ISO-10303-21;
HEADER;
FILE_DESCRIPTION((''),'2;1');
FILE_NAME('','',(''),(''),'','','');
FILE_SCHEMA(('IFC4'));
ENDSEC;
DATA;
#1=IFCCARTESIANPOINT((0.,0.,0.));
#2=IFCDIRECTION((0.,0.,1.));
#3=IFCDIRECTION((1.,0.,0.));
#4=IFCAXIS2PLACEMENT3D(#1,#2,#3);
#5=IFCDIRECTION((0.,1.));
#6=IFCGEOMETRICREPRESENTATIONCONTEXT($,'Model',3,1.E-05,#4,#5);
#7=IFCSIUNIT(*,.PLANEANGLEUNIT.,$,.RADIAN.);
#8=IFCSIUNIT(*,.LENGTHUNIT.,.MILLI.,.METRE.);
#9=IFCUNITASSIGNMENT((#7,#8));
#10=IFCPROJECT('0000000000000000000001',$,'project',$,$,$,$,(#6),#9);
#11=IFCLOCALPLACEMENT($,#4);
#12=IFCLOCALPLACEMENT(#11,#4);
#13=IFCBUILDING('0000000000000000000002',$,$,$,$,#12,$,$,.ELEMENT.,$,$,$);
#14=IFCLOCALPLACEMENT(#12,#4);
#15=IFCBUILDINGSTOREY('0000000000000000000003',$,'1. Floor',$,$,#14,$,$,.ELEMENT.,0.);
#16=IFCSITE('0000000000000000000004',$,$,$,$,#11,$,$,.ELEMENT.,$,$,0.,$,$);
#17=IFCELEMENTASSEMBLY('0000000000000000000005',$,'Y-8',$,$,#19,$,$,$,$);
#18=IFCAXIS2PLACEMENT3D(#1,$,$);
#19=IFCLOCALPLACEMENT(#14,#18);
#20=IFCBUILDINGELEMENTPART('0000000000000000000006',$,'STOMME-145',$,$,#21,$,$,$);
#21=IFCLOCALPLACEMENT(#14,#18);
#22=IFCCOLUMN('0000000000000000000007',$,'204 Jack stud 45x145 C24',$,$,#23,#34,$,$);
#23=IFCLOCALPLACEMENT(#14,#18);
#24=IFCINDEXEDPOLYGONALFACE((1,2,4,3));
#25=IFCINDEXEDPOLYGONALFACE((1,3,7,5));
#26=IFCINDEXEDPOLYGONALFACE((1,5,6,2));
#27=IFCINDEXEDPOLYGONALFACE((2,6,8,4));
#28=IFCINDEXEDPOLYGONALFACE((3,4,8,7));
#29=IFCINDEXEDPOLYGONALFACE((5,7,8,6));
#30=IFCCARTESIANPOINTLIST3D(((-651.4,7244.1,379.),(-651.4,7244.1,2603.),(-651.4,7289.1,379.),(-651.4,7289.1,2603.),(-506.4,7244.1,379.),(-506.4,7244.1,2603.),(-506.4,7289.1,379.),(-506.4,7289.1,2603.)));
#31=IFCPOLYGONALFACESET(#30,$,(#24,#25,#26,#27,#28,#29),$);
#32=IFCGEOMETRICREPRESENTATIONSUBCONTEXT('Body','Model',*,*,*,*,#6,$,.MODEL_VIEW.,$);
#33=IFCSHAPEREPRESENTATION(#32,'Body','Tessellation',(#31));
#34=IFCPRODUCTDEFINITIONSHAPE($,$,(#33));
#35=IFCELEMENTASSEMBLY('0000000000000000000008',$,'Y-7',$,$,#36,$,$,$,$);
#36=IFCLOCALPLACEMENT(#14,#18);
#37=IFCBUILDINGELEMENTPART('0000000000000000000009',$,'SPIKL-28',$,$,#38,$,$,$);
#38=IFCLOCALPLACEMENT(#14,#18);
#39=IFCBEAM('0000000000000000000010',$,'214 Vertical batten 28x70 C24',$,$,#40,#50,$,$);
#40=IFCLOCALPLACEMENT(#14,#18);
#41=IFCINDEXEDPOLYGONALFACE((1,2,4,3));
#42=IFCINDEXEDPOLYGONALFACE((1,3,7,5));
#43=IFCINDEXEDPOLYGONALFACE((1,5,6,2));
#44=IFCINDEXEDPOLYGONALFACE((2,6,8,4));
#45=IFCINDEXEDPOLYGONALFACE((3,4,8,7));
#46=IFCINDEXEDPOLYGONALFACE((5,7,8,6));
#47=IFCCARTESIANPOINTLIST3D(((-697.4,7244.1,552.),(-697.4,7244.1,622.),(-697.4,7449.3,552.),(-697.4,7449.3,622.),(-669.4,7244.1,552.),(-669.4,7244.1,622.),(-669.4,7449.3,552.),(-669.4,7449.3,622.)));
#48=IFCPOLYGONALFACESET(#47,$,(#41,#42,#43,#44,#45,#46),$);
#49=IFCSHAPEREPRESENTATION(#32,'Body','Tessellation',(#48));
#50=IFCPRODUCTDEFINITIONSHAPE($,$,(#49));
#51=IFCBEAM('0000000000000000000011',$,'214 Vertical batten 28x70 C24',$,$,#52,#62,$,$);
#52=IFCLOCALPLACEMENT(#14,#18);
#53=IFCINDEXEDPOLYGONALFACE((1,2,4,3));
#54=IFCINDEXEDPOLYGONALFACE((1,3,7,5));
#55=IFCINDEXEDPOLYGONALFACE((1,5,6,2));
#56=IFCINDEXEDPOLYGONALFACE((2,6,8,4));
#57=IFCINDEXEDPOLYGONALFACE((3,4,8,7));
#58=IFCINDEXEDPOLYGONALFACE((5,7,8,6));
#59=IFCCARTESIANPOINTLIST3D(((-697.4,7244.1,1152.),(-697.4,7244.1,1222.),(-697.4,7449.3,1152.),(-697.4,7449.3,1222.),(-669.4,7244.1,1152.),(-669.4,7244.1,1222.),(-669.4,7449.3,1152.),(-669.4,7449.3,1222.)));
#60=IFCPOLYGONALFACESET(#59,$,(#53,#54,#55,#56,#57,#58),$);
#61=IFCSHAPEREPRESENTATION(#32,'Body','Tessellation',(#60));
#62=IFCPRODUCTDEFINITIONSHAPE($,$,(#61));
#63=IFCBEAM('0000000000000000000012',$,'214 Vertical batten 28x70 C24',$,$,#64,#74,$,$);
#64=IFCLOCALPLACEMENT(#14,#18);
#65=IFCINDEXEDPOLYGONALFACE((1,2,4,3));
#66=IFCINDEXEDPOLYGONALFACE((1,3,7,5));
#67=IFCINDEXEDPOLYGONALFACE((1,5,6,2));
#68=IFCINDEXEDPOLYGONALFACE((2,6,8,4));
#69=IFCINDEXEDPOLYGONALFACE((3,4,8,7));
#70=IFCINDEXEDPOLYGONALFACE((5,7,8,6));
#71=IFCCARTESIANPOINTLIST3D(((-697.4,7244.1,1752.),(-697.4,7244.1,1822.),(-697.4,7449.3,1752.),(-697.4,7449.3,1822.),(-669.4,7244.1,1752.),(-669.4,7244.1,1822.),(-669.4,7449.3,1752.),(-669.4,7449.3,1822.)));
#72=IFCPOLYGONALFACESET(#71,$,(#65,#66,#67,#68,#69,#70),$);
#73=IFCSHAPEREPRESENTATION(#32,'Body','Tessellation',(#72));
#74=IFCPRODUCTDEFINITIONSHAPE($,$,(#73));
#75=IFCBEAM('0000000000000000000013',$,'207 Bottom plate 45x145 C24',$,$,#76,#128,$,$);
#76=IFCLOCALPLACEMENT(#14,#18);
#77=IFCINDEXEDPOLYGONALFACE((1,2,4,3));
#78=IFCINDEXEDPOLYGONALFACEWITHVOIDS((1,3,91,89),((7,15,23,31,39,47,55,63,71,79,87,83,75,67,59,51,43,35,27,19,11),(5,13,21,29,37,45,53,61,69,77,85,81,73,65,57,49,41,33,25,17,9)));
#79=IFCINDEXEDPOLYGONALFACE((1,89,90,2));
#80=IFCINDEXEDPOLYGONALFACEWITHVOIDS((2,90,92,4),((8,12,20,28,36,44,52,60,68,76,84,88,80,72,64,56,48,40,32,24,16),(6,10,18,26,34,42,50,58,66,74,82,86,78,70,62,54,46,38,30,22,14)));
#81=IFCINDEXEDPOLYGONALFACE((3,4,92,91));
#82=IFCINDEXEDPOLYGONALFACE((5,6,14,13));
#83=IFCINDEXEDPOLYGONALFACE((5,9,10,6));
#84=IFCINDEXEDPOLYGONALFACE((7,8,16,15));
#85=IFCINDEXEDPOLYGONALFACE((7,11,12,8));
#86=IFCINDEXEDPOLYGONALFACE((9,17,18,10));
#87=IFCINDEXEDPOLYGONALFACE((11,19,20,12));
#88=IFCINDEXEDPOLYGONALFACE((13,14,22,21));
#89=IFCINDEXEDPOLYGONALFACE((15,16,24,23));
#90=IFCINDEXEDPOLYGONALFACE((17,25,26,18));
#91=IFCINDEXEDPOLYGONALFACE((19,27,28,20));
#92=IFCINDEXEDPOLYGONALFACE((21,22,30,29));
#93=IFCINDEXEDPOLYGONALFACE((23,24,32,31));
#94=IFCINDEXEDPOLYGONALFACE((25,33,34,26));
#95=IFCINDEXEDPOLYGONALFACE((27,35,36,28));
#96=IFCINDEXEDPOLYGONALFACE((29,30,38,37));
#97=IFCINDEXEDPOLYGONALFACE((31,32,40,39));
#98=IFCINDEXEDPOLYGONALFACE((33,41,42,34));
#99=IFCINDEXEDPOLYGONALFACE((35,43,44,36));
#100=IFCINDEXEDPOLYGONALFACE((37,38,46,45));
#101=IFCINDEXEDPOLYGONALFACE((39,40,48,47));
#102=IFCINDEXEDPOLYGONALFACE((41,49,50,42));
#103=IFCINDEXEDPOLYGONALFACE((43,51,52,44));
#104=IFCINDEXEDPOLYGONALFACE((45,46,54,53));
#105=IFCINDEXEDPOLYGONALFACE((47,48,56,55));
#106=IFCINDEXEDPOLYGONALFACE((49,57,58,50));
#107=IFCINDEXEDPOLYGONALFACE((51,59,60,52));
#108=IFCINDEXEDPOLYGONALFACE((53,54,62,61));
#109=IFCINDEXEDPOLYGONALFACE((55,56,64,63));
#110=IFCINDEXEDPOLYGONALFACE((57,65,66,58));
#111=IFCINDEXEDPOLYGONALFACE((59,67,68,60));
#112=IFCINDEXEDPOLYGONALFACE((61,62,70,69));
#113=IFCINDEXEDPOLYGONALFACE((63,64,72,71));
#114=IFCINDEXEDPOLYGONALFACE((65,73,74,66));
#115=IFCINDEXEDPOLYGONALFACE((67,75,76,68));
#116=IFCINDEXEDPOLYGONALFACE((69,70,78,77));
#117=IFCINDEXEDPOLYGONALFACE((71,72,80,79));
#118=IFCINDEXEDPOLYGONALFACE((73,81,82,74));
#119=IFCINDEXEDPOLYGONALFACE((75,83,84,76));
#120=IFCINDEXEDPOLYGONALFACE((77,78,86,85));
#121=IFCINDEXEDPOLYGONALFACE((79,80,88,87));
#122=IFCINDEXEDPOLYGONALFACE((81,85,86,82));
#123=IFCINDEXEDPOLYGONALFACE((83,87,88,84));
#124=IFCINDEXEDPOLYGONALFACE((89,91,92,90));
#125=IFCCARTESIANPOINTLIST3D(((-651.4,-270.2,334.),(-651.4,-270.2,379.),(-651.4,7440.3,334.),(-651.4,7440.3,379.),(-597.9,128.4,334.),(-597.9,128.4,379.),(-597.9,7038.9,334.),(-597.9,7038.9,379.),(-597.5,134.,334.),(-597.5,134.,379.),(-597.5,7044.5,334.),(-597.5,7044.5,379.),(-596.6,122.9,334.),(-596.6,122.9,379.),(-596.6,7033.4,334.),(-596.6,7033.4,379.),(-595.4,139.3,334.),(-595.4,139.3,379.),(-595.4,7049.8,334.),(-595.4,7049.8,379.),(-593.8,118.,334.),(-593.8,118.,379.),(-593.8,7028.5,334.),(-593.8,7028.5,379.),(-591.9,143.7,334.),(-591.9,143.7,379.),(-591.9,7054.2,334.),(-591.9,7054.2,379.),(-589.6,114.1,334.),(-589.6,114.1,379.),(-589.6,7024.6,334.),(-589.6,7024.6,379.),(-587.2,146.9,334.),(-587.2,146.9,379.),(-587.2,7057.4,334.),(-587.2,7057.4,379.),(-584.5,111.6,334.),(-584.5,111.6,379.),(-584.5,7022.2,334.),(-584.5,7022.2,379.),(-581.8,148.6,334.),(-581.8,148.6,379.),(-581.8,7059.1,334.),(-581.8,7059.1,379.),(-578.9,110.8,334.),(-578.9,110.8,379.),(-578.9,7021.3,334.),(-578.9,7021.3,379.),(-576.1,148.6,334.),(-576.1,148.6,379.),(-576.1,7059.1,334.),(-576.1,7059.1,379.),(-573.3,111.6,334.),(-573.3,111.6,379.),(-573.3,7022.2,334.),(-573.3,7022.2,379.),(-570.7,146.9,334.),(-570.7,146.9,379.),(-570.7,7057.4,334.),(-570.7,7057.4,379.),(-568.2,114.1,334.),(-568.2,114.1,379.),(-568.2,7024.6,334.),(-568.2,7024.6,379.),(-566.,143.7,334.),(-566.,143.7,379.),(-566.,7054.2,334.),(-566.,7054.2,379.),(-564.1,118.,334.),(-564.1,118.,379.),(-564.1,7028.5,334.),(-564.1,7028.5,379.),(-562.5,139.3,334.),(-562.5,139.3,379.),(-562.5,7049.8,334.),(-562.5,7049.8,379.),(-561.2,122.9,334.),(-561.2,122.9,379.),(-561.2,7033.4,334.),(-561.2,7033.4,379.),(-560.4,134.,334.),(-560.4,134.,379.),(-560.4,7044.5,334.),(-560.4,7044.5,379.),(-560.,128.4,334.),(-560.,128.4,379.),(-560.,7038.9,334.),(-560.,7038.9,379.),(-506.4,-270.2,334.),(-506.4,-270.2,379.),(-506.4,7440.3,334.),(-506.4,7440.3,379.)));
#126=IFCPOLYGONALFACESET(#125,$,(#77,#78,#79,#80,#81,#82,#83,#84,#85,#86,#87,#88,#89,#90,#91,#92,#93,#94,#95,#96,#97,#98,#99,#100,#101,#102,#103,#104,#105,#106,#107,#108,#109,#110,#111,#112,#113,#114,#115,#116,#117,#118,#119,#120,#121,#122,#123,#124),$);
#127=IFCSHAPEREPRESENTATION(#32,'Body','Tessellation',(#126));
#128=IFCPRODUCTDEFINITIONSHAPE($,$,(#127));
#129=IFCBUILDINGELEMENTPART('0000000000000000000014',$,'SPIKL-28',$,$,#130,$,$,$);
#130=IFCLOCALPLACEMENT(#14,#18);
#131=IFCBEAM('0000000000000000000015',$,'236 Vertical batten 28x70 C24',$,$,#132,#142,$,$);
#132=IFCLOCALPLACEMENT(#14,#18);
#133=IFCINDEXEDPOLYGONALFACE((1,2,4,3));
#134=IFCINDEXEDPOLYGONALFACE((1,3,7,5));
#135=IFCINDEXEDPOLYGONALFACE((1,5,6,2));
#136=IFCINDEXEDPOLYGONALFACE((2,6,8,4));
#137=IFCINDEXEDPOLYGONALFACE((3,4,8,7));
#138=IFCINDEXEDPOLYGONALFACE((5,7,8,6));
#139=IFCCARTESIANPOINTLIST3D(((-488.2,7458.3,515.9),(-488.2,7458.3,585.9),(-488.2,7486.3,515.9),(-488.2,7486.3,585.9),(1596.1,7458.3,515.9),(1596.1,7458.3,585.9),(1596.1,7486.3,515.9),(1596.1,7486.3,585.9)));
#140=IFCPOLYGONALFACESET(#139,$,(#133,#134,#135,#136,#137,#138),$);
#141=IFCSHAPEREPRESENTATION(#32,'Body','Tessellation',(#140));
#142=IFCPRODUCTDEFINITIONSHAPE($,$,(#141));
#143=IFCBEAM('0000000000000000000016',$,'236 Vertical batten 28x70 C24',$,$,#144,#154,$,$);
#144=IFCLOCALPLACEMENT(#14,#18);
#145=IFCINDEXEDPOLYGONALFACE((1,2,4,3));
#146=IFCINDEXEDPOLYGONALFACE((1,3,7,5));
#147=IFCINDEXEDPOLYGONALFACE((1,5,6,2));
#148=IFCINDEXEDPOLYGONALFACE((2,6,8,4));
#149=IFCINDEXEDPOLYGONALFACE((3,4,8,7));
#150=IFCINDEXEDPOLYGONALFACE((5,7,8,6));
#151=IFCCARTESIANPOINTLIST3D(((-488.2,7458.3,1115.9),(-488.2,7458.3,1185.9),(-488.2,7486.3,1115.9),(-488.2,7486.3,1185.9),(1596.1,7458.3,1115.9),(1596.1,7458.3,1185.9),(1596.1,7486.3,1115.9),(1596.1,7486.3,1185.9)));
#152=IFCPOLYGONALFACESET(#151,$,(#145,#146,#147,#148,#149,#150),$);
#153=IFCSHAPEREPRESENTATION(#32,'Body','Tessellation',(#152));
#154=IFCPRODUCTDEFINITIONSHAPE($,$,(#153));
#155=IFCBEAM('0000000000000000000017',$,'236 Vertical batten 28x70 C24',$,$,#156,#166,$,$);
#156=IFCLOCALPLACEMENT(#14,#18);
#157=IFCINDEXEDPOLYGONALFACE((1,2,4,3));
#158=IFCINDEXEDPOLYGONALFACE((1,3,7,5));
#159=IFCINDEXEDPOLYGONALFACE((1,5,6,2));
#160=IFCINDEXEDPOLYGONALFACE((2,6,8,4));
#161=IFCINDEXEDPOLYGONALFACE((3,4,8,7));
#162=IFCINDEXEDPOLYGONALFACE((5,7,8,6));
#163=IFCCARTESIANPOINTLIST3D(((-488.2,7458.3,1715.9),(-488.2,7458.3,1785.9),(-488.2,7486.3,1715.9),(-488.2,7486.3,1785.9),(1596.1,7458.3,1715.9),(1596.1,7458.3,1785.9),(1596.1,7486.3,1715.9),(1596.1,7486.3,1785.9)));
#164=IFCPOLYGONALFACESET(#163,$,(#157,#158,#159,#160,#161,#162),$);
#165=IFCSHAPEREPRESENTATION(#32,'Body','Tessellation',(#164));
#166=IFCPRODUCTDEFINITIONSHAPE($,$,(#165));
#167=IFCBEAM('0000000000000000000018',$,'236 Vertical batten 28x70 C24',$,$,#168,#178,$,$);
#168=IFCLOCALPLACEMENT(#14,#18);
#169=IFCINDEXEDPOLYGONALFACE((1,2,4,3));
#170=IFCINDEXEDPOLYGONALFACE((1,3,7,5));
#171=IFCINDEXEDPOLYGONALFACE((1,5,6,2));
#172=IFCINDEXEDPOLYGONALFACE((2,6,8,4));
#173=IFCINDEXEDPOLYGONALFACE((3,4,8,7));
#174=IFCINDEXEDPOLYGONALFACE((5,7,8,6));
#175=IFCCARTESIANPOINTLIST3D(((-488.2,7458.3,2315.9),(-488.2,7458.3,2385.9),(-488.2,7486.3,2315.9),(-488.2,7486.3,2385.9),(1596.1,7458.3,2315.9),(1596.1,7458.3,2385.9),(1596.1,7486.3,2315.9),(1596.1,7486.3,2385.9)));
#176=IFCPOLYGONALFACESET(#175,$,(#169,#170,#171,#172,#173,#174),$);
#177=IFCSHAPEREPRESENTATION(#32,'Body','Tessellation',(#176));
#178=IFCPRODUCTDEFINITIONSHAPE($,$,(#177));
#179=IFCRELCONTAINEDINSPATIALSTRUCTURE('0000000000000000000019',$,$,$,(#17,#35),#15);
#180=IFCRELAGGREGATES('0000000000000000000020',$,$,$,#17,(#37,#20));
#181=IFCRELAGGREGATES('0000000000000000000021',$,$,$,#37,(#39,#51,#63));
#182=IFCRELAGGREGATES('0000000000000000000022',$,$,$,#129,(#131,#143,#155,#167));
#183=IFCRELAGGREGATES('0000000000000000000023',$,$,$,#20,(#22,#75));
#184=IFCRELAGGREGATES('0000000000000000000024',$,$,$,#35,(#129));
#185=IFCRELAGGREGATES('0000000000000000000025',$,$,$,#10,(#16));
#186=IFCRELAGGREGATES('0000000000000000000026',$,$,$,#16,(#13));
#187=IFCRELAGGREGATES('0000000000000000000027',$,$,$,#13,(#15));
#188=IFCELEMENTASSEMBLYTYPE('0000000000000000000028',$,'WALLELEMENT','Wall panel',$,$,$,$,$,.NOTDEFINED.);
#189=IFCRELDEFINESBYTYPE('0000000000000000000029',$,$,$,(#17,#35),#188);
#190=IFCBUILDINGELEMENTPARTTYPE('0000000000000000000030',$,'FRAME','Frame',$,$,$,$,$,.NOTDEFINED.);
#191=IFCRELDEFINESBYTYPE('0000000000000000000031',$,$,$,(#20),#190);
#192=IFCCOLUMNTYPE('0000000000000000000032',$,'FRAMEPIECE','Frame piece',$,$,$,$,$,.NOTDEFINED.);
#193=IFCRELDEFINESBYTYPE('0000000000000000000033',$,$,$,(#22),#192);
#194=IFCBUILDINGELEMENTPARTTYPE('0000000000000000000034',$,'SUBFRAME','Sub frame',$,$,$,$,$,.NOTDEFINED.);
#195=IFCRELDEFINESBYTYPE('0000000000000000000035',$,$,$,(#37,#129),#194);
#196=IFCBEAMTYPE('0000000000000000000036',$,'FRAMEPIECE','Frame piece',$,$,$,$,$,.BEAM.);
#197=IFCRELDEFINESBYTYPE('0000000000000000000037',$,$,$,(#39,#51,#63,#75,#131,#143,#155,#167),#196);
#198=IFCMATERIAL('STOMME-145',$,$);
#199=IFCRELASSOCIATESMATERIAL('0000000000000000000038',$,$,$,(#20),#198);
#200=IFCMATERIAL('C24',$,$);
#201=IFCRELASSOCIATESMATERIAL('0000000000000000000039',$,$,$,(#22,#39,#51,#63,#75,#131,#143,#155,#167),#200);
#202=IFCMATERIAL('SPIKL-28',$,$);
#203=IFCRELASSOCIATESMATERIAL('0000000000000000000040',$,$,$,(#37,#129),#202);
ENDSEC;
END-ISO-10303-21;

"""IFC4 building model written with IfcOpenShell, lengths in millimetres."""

from ifc_helpers import new_model, si_unit, direction, frame, origin_with_axes, origin_2d_with_axis, place, context, subcontext, project, spatial, rectangle, circle, extrude, boolean, material, type_object, element, aggregate, save


model = new_model("IFC4")

# Units and contexts
model_context = context("Model", 3, precision=1e-05, world=origin_with_axes(), true_north=direction((0.0, 1.0)))
body_context = subcontext(model_context, "Body", "Model", "MODEL_VIEW")
ifc_project = project(units=[si_unit("PLANEANGLEUNIT", "RADIAN"), si_unit("LENGTHUNIT", "METRE", prefix="MILLI")], contexts=[model_context])

# Site, building, storey
site_placement = place(None, origin_with_axes())
site = spatial("IfcSite", under=ifc_project, at=site_placement, CompositionType="ELEMENT", RefElevation=0.0)
building_placement = place(site_placement, origin_with_axes())
building = spatial("IfcBuilding", under=site, at=building_placement, CompositionType="ELEMENT")
storey_placement = place(building_placement, origin_with_axes())
storey = spatial("IfcBuildingStorey", under=building, at=storey_placement, Name="1. Floor", CompositionType="ELEMENT", Elevation=0.0)

# Element assemblies, building element part, column
element_assembly_type = type_object("IfcElementAssemblyType", Name="WALLELEMENT", Description="Wall panel", PredefinedType="NOTDEFINED")
assembly_1_placement = place(storey_placement, origin_with_axes())
assembly_1 = element("IfcElementAssembly", 1, at=assembly_1_placement, inside=storey, type_object=element_assembly_type, Name="Y-8")
ifc_material_1 = material(Name="STOMME-145")
building_element_part_type_1 = type_object("IfcBuildingElementPartType", Name="FRAME", Description="Frame", PredefinedType="NOTDEFINED")
building_element_part_1_placement = place(storey_placement, origin_with_axes())
building_element_part_1 = element("IfcBuildingElementPart", 2, at=building_element_part_1_placement, type_object=building_element_part_type_1, material=ifc_material_1, Name="STOMME-145")
ifc_material_2 = material(Name="C24")
column_type = type_object("IfcColumnType", Name="FRAMEPIECE", Description="Frame piece", PredefinedType="NOTDEFINED")
column_1_placement = place(storey_placement, frame((-578.9, 7266.6, 379.0), z_axis=(0.0, 0.0, 1.0), x_axis=(0.0, 1.0, 0.0)))
column_1 = element("IfcColumn", 3, at=column_1_placement, type_object=column_type, material=ifc_material_2, Name="204 Jack stud 45x145 C24", context=body_context, shape_type="SweptSolid", body=[
    extrude(rectangle(XDim=45.0, YDim=145.0, at=origin_2d_with_axis()), origin_with_axes(), (0.0, 0.0, 1.0), 2224.0),
])
assembly_2_placement = place(storey_placement, origin_with_axes())
assembly_2 = element("IfcElementAssembly", 4, at=assembly_2_placement, inside=storey, type_object=element_assembly_type, Name="Y-7")

# Building element part
ifc_material_3 = material(Name="SPIKL-28")
building_element_part_type_2 = type_object("IfcBuildingElementPartType", Name="SUBFRAME", Description="Sub frame", PredefinedType="NOTDEFINED")
building_element_part_2_placement = place(storey_placement, origin_with_axes())
building_element_part_2 = element("IfcBuildingElementPart", 5, at=building_element_part_2_placement, type_object=building_element_part_type_2, material=ifc_material_3, Name="SPIKL-28")
aggregate(assembly_1, [building_element_part_2, building_element_part_1])

# Beams
beam_type = type_object("IfcBeamType", Name="FRAMEPIECE", Description="Frame piece", PredefinedType="BEAM")
beam_1_placement = place(storey_placement, frame((-683.4, 7244.1, 587.0), z_axis=(0.0, 1.0, 0.0), x_axis=(-1.0, 0.0, 0.0)))
beam_1 = element("IfcBeam", 6, at=beam_1_placement, type_object=beam_type, material=ifc_material_2, Name="214 Vertical batten 28x70 C24", context=body_context, shape_type="SweptSolid", body=[
    extrude(rectangle(XDim=28.0, YDim=70.0, at=origin_2d_with_axis()), origin_with_axes(), (0.0, 0.0, 1.0), 205.2),
])
beam_2_placement = place(storey_placement, frame((-683.4, 7244.1, 1187.0), z_axis=(0.0, 1.0, 0.0), x_axis=(-1.0, 0.0, 0.0)))
beam_2 = element("IfcBeam", 7, at=beam_2_placement, type_object=beam_type, material=ifc_material_2, Name="214 Vertical batten 28x70 C24", context=body_context, shape_type="SweptSolid", body=[
    extrude(rectangle(XDim=28.0, YDim=70.0, at=origin_2d_with_axis()), origin_with_axes(), (0.0, 0.0, 1.0), 205.2),
])
beam_3_placement = place(storey_placement, frame((-683.4, 7244.1, 1787.0), z_axis=(0.0, 1.0, 0.0), x_axis=(-1.0, 0.0, 0.0)))
beam_3 = element("IfcBeam", 8, at=beam_3_placement, type_object=beam_type, material=ifc_material_2, Name="214 Vertical batten 28x70 C24", context=body_context, shape_type="SweptSolid", body=[
    extrude(rectangle(XDim=28.0, YDim=70.0, at=origin_2d_with_axis()), origin_with_axes(), (0.0, 0.0, 1.0), 205.2),
])
aggregate(building_element_part_2, [beam_1, beam_2, beam_3])
beam_4_placement = place(storey_placement, frame((-578.9, 7440.3, 356.5), z_axis=(0.0, -1.0, 0.0), x_axis=(0.0, 0.0, 1.0)))
beam_4 = element("IfcBeam", 9, at=beam_4_placement, type_object=beam_type, material=ifc_material_2, Name="207 Bottom plate 45x145 C24", context=body_context, shape_type="CSG", body=[
    boolean("DIFFERENCE", boolean("DIFFERENCE", extrude(rectangle(XDim=45.0, YDim=145.0, at=origin_2d_with_axis()), origin_with_axes(), (0.0, 0.0, 1.0), 7710.5), extrude(circle(Radius=19.0, at=origin_2d_with_axis()), frame((-45.0, 0.0, 400.0), z_axis=(-1.0, 0.0, 0.0), x_axis=(0.0, 0.0, 1.0)), (0.0, 0.0, -1.0), 90.0)), extrude(circle(Radius=19.0, at=origin_2d_with_axis()), frame((-45.0, 0.0, 7310.5), z_axis=(-1.0, 0.0, 0.0), x_axis=(0.0, 0.0, 1.0)), (0.0, 0.0, -1.0), 90.0)),
])

# Building element part, beams
building_element_part_3_placement = place(storey_placement, origin_with_axes())
building_element_part_3 = element("IfcBuildingElementPart", 10, at=building_element_part_3_placement, type_object=building_element_part_type_2, material=ifc_material_3, Name="SPIKL-28")
beam_5_placement = place(storey_placement, frame((-488.2, 7472.3, 550.9), z_axis=(1.0, 0.0, 0.0), x_axis=(0.0, 1.0, 0.0)))
beam_5 = element("IfcBeam", 11, at=beam_5_placement, type_object=beam_type, material=ifc_material_2, Name="236 Vertical batten 28x70 C24", context=body_context, shape_type="SweptSolid", body=[
    extrude(rectangle(XDim=28.0, YDim=70.0, at=origin_2d_with_axis()), origin_with_axes(), (0.0, 0.0, 1.0), 2084.3),
])
beam_6_placement = place(storey_placement, frame((-488.2, 7472.3, 1150.9), z_axis=(1.0, 0.0, 0.0), x_axis=(0.0, 1.0, 0.0)))
beam_6 = element("IfcBeam", 12, at=beam_6_placement, type_object=beam_type, material=ifc_material_2, Name="236 Vertical batten 28x70 C24", context=body_context, shape_type="SweptSolid", body=[
    extrude(rectangle(XDim=28.0, YDim=70.0, at=origin_2d_with_axis()), origin_with_axes(), (0.0, 0.0, 1.0), 2084.3),
])
beam_7_placement = place(storey_placement, frame((-488.2, 7472.3, 1750.9), z_axis=(1.0, 0.0, 0.0), x_axis=(0.0, 1.0, 0.0)))
beam_7 = element("IfcBeam", 13, at=beam_7_placement, type_object=beam_type, material=ifc_material_2, Name="236 Vertical batten 28x70 C24", context=body_context, shape_type="SweptSolid", body=[
    extrude(rectangle(XDim=28.0, YDim=70.0, at=origin_2d_with_axis()), origin_with_axes(), (0.0, 0.0, 1.0), 2084.3),
])
beam_8_placement = place(storey_placement, frame((-488.2, 7472.3, 2350.9), z_axis=(1.0, 0.0, 0.0), x_axis=(0.0, 1.0, 0.0)))
beam_8 = element("IfcBeam", 14, at=beam_8_placement, type_object=beam_type, material=ifc_material_2, Name="236 Vertical batten 28x70 C24", context=body_context, shape_type="SweptSolid", body=[
    extrude(rectangle(XDim=28.0, YDim=70.0, at=origin_2d_with_axis()), origin_with_axes(), (0.0, 0.0, 1.0), 2084.3),
])
aggregate(building_element_part_3, [beam_5, beam_6, beam_7, beam_8])

aggregate(building_element_part_1, [column_1, beam_4])

aggregate(assembly_2, [building_element_part_3])

save(model, "model.ifc")
